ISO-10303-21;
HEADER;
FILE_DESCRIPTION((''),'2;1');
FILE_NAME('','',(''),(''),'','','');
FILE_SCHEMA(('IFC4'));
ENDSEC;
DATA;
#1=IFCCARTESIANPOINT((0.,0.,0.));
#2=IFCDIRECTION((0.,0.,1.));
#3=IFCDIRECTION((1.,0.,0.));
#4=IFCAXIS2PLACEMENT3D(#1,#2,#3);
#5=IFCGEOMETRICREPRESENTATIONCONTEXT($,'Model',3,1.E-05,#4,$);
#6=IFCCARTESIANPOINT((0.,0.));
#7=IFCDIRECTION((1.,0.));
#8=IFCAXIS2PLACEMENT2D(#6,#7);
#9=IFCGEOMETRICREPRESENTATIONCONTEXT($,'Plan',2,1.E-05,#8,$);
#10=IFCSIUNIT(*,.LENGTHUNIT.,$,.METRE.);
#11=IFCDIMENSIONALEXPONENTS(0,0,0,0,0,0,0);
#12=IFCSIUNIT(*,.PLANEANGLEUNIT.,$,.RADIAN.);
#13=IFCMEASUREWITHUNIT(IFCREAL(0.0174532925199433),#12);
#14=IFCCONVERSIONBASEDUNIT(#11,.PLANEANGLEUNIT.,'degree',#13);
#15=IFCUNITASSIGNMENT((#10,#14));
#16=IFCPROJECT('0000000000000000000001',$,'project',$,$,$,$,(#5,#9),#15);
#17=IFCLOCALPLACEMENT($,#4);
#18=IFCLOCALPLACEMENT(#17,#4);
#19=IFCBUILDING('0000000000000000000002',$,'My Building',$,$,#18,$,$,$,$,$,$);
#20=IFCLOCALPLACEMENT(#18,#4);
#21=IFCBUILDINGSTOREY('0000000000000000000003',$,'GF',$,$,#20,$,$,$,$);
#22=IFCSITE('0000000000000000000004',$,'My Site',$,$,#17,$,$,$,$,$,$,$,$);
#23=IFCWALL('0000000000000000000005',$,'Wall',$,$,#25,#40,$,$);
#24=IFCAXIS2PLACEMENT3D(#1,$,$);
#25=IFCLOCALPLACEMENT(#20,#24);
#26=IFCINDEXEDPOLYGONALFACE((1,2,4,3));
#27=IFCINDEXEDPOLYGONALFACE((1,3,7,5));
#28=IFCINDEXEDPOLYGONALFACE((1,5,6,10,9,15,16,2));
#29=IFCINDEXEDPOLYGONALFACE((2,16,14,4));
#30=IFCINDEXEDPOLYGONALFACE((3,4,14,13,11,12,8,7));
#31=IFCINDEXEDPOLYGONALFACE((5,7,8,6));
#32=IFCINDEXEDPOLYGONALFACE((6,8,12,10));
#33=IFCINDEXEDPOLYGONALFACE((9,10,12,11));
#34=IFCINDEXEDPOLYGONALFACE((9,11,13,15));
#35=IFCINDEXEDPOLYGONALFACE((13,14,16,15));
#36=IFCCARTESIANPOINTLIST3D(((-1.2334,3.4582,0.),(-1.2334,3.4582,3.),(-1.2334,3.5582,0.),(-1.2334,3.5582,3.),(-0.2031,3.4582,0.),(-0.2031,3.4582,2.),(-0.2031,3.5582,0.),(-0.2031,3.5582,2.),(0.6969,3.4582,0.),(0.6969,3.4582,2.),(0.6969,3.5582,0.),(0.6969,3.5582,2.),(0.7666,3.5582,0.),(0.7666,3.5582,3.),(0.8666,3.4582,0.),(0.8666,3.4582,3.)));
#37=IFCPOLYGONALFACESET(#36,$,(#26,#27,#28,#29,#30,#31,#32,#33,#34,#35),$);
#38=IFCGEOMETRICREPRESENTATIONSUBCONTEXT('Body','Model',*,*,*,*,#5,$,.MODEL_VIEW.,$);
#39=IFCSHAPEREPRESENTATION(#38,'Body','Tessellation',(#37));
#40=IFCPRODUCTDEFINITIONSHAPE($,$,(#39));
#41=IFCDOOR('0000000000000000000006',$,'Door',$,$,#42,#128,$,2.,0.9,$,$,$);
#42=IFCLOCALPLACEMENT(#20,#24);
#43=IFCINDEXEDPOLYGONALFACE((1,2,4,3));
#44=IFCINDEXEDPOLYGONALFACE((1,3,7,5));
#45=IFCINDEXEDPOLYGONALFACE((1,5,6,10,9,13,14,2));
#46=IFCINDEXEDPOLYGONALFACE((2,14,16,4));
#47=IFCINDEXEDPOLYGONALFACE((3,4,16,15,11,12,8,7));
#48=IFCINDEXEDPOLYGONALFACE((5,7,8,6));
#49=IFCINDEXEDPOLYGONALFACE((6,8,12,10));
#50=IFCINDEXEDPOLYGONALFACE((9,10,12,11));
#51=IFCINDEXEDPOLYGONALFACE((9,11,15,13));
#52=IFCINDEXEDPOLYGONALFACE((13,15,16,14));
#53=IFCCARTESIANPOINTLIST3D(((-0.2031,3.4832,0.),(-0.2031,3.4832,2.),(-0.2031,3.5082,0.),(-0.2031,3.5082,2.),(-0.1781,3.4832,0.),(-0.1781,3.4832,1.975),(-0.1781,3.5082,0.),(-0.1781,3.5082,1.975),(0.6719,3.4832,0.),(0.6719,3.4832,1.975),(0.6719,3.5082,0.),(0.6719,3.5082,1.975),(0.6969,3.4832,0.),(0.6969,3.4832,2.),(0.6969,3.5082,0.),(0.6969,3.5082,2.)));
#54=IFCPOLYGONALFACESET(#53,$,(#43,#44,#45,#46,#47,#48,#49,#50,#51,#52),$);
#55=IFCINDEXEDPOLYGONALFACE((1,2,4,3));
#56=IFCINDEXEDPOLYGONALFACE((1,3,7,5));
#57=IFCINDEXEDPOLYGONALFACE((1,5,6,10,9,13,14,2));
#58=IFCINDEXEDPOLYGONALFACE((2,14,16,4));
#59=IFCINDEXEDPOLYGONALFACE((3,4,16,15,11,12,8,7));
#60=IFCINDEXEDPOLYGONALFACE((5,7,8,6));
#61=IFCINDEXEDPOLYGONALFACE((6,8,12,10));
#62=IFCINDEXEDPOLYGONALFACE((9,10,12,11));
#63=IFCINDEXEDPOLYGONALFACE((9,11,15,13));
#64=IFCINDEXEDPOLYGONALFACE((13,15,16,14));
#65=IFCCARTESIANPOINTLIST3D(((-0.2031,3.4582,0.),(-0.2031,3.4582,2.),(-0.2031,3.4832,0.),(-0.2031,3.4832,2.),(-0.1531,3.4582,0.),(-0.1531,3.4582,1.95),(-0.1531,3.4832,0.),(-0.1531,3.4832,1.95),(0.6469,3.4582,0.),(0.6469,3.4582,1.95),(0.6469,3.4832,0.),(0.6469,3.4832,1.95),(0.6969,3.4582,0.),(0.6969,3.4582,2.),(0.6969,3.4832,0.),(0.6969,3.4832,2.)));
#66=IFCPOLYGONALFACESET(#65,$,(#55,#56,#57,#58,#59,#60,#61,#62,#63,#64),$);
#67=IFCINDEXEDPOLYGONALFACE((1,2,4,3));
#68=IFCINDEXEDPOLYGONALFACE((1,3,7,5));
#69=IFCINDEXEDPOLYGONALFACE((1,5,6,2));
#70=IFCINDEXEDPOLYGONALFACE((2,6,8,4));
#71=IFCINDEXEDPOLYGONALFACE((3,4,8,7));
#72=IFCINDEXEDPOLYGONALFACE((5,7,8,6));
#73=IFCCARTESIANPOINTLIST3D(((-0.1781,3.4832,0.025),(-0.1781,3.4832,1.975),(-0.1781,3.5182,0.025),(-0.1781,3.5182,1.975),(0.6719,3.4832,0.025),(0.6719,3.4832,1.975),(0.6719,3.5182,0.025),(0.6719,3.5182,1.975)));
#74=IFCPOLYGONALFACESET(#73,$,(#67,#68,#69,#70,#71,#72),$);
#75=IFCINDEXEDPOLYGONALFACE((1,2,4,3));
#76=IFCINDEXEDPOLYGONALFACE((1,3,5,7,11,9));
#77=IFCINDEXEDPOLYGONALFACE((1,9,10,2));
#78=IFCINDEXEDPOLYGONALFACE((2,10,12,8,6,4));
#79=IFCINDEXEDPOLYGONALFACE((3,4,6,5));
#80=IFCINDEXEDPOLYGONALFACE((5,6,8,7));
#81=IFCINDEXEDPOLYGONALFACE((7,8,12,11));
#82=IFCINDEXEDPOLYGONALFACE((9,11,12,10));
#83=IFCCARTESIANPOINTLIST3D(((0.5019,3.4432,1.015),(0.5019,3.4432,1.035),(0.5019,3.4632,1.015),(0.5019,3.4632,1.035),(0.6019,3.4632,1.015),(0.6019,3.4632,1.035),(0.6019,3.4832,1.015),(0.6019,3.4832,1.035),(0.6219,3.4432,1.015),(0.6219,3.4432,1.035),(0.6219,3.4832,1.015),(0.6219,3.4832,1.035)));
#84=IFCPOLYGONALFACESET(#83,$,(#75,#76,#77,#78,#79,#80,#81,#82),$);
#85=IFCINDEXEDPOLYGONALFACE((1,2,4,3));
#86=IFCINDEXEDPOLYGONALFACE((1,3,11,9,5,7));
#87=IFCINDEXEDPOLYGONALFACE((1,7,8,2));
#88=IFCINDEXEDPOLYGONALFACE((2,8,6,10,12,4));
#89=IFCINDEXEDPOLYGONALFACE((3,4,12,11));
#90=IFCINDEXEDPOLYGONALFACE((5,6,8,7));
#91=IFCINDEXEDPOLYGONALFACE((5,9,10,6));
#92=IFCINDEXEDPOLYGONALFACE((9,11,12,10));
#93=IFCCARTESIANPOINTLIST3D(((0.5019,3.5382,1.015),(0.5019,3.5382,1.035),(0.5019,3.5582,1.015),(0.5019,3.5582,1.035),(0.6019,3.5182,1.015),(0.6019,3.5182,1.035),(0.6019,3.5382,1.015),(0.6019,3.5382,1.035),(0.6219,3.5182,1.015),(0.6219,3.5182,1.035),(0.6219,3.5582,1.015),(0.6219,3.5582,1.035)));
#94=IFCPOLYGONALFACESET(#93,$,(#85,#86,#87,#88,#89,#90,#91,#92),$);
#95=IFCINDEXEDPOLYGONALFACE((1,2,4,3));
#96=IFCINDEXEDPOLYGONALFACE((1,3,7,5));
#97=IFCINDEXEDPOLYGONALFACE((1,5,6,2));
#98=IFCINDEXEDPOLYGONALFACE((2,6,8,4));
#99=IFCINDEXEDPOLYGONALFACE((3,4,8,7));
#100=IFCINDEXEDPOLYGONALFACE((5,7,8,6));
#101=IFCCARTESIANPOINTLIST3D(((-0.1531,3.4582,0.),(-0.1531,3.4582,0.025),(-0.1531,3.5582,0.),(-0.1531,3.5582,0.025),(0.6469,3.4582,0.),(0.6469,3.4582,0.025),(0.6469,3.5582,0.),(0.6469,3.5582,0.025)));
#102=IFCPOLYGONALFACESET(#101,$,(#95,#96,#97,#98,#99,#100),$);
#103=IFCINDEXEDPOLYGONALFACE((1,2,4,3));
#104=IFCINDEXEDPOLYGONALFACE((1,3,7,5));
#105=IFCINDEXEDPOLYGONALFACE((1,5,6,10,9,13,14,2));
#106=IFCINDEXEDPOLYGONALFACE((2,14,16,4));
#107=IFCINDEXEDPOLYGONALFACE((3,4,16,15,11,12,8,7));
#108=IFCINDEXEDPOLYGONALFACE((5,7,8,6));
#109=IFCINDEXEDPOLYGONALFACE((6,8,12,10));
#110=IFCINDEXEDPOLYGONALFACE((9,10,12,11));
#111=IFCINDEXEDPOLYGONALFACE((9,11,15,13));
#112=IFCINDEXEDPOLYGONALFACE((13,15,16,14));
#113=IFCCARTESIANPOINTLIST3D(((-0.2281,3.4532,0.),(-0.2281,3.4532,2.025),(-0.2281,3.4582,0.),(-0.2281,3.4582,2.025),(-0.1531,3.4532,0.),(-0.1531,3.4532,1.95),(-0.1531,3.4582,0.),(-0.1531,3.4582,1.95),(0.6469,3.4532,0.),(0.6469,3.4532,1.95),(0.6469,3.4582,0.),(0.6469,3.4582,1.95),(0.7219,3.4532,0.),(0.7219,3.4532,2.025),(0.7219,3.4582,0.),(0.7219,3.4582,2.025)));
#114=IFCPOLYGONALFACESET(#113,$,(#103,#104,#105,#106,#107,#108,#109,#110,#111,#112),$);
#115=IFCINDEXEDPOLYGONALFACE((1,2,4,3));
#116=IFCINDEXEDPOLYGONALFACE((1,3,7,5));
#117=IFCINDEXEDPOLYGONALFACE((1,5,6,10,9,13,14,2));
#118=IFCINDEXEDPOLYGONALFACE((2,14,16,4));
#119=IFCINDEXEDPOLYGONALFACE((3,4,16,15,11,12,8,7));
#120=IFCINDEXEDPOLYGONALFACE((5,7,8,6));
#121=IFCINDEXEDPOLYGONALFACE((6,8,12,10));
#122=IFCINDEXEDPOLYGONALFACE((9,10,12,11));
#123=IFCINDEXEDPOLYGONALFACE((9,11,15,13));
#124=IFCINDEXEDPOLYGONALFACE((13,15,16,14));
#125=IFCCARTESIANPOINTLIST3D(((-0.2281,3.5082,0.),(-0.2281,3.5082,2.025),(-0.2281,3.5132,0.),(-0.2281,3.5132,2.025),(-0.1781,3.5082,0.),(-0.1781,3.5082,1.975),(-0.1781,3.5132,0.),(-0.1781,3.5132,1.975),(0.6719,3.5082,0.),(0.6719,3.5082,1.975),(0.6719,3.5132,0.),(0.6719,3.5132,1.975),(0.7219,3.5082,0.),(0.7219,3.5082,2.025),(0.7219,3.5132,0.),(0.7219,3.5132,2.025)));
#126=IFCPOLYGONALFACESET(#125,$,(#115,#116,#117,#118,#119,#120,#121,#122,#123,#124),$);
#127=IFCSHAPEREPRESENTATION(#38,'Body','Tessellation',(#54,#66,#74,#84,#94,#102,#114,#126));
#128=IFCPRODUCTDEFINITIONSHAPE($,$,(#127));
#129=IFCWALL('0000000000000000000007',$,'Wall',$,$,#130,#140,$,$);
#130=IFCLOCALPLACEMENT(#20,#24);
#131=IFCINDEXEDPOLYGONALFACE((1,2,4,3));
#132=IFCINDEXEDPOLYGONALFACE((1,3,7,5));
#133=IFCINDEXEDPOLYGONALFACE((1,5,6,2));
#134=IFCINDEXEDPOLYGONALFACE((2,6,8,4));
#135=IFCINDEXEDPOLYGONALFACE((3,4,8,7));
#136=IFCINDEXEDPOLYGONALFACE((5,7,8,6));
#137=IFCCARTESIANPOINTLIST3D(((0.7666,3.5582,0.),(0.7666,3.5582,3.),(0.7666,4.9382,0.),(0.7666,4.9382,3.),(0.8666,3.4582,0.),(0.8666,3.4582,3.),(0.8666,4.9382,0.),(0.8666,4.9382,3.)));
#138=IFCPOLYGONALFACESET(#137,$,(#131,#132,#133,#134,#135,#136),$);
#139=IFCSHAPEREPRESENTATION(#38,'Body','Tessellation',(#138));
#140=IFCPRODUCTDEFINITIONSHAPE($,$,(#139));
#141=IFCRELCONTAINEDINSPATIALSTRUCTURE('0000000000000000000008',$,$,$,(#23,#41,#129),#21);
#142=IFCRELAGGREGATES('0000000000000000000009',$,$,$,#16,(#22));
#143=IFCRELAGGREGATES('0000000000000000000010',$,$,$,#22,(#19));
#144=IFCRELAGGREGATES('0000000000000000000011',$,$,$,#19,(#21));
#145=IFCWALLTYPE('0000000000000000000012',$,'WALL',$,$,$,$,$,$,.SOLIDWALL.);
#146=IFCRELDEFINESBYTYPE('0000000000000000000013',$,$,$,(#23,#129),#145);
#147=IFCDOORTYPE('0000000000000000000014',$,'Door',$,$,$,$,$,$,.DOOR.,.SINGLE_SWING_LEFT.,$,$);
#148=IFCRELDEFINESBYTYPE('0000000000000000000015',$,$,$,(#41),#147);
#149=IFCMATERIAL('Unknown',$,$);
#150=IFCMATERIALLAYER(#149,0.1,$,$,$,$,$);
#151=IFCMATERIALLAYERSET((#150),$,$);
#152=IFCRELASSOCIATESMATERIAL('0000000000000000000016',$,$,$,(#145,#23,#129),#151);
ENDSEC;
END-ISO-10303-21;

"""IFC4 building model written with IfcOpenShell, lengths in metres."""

from ifc_helpers import new_model, entity, si_unit, converted_unit, frame, origin_with_axes, origin_2d_with_axis, place, context, subcontext, project, spatial, line, indexed_curve, outline, extrude, shape, source, transform, mapped, material, layer, layer_set, layer_usage, type_object, type_shapes, element, fill, save


model = new_model("IFC4")

# Units and contexts
model_context = context("Model", 3, precision=1e-05, world=origin_with_axes())
plan_context = context("Plan", 2, precision=1e-05, world=origin_2d_with_axis())
body_context_1 = subcontext(model_context, "Body", "Model", "MODEL_VIEW")
body_context_2 = subcontext(plan_context, "Body", "Plan", "PLAN_VIEW")
ifc_project = project(units=[si_unit("LENGTHUNIT", "METRE"), converted_unit("PLANEANGLEUNIT", "degree", entity("IfcReal", 0.0174532925199433), si_unit("PLANEANGLEUNIT", "RADIAN"), dimensions=[0, 0, 0, 0, 0, 0, 0])], contexts=[model_context, plan_context])

# Site, building, storey
site_placement = place(None, origin_with_axes())
site = spatial("IfcSite", under=ifc_project, at=site_placement, Name="My Site")
building_placement = place(site_placement, origin_with_axes())
building = spatial("IfcBuilding", under=site, at=building_placement, Name="My Building")
storey_placement = place(building_placement, origin_with_axes())
storey = spatial("IfcBuildingStorey", under=building, at=storey_placement, Name="GF")

# Shared definitions
ifc_material = material(Name="Unknown")

# Shared definitions
ifc_layer = layer(ifc_material, 0.1)
ifc_layer_set = layer_set([ifc_layer])
wall_type = type_object("IfcWallType", Name="WALL", PredefinedType="SOLIDWALL", material=ifc_layer_set)

# Wall, opening, door
ifc_layer_usage_1 = layer_usage(ifc_layer_set, "AXIS2", "POSITIVE", 0.0)
wall_1_placement = place(storey_placement, frame((-1.2334, 3.4582, 0.0), z_axis=(0.0, 0.0, 1.0), x_axis=(1.0, 0.0, 0.0)))
wall_1 = element("IfcWall", 1, at=wall_1_placement, inside=storey, type_object=wall_type, material=ifc_layer_usage_1, Name="Wall", context=body_context_1, shape_type="SweptSolid", body=[
    extrude(outline(indexed_curve([(0.0, 0.0), (0.0, 0.1), (2.0, 0.1), (2.1, 0.0)], segments=[line(1, 2, 3, 4, 1)])), origin_with_axes(), (0.0, 0.0, 1.0), 3.0),
])
shared_shape_1 = source(origin_with_axes(), body_context_1, "Body", "SweptSolid", [
    extrude(outline(indexed_curve([(0.0, 0.0), (0.9, 0.0), (0.9, 2.0), (0.0, 2.0)], segments=[line(1, 2, 3, 4, 1)])), frame((0.0, -0.6, 0.0), z_axis=(0.0, -1.0, 0.0), x_axis=(1.0, 0.0, 0.0)), (0.0, 0.0, -1.0), 1.2),
])
opening_1_placement = place(wall_1_placement, frame((1.0303, 0.0, 0.0), z_axis=(0.0, 0.0, 1.0), x_axis=(1.0, 0.0, 0.0)))
opening_1 = element("IfcOpeningElement", 2, at=opening_1_placement, cuts=wall_1, PredefinedType="OPENING", context=body_context_1, shape_type="MappedRepresentation", body=[
    mapped(shared_shape_1, transform((0.0, 0.0, 0.0), x_axis=(1.0, 0.0, 0.0), y_axis=(0.0, 1.0, 0.0), z_axis=(0.0, 0.0, 1.0), scale=1.0)),
])
door_type = type_object("IfcDoorType", Name="Door", OperationType="SINGLE_SWING_LEFT", PredefinedType="DOOR")
shared_shape_2 = source(origin_with_axes(), body_context_1, "Body", "SweptSolid", [
    extrude(outline(indexed_curve([(0.0, 0.0), (0.0, 2.0), (0.9, 2.0), (0.9, 0.0), (0.875, 0.0), (0.875, 1.975), (0.025, 1.975), (0.025, 0.0)], segments=[line(1, 2, 3, 4, 5, 6, 7, 8, 1)])), frame((0.0, 0.025, 0.0), z_axis=(0.0, -1.0, 0.0), x_axis=(1.0, 0.0, 0.0)), (0.0, 0.0, -1.0), 0.025),
    extrude(outline(indexed_curve([(0.0, 0.0), (0.0, 2.0), (0.9, 2.0), (0.9, 0.0), (0.85, 0.0), (0.85, 1.95), (0.05, 1.95), (0.05, 0.0)], segments=[line(1, 2, 3, 4, 5, 6, 7, 8, 1)])), frame((0.0, 0.0, 0.0), z_axis=(0.0, -1.0, 0.0), x_axis=(1.0, 0.0, 0.0)), (0.0, 0.0, -1.0), 0.025),
    extrude(outline(indexed_curve([(0.0, 0.0), (0.85, 0.0), (0.85, 0.035), (0.0, 0.035)], segments=[line(1, 2, 3, 4, 1)])), frame((0.025, 0.025, 0.025), z_axis=(0.0, 0.0, 1.0), x_axis=(1.0, 0.0, 0.0)), (0.0, 0.0, 1.0), 1.95),
    extrude(outline(indexed_curve([(0.0, 0.0), (0.0, -0.04), (-0.12, -0.04), (-0.12, -0.02), (-0.02, -0.02), (-0.02, 0.0)], segments=[line(1, 2, 3, 4, 5, 6, 1)])), frame((0.825, 0.025, 1.015), z_axis=(0.0, 0.0, 1.0), x_axis=(1.0, 0.0, 0.0)), (0.0, 0.0, 1.0), 0.02),
    extrude(outline(indexed_curve([(0.0, 0.0), (0.0, 0.04), (-0.12, 0.04), (-0.12, 0.02), (-0.02, 0.02), (-0.02, 0.0)], segments=[line(1, 2, 3, 4, 5, 6, 1)])), frame((0.825, 0.06, 1.015), z_axis=(0.0, 0.0, 1.0), x_axis=(1.0, 0.0, 0.0)), (0.0, 0.0, 1.0), 0.02),
    extrude(outline(indexed_curve([(0.0, 0.0), (0.8, 0.0), (0.8, 0.1), (0.0, 0.1)], segments=[line(1, 2, 3, 4, 1)])), frame((0.05, 0.0, 0.0), z_axis=(0.0, 0.0, 1.0), x_axis=(1.0, 0.0, 0.0)), (0.0, 0.0, 1.0), 0.025),
    extrude(outline(indexed_curve([(0.0, 0.0), (0.0, 2.025), (0.95, 2.025), (0.95, 0.0), (0.875, 0.0), (0.875, 1.95), (0.075, 1.95), (0.075, 0.0)], segments=[line(1, 2, 3, 4, 5, 6, 7, 8, 1)])), frame((-0.025, -0.005, 0.0), z_axis=(0.0, -1.0, 0.0), x_axis=(1.0, 0.0, 0.0)), (0.0, 0.0, -1.0), 0.005),
    extrude(outline(indexed_curve([(0.0, 0.0), (0.0, 2.025), (0.95, 2.025), (0.95, 0.0), (0.9, 0.0), (0.9, 1.975), (0.05, 1.975), (0.05, 0.0)], segments=[line(1, 2, 3, 4, 5, 6, 7, 8, 1)])), frame((-0.025, 0.05, 0.0), z_axis=(0.0, -1.0, 0.0), x_axis=(1.0, 0.0, 0.0)), (0.0, 0.0, -1.0), 0.005),
])
shared_shape_3 = source(origin_with_axes(), body_context_2, "Body", "Curve2D", [
    entity("IfcIndexedPolyCurve", entity("IfcCartesianPointList2D", [[0.0, 0.0], [0.0, 0.05], [0.025, 0.05], [0.025, 0.025], [0.05, 0.025], [0.05, 0.0]]), [entity("IfcLineIndex", [1, 2, 3, 4, 5, 6, 1])]),
    entity("IfcIndexedPolyCurve", entity("IfcCartesianPointList2D", [[0.9, 0.0], [0.9, 0.05], [0.875, 0.05], [0.875, 0.025], [0.85, 0.025], [0.85, 0.0]]), [entity("IfcLineIndex", [1, 2, 3, 4, 5, 6, 1])]),
    entity("IfcTrimmedCurve", entity("IfcEllipse", entity("IfcAxis2Placement2D", entity("IfcCartesianPoint", [0.06, 0.05]), entity("IfcDirection", [1.0, 0.0])), 0.815, 0.85), [entity("IfcCartesianPoint", [0.875, 0.05])], [entity("IfcCartesianPoint", [0.06, 0.9])], True, "CARTESIAN"),
    entity("IfcIndexedPolyCurve", entity("IfcCartesianPointList2D", [[0.025, 0.05], [0.06, 0.05], [0.06, 0.9], [0.025, 0.9]]), [entity("IfcLineIndex", [1, 2, 3, 4, 1])]),
])
type_shapes(door_type, [shared_shape_2, shared_shape_3])
door_placement = place(opening_1_placement, origin_with_axes())
door = element("IfcDoor", 3, at=door_placement, inside=storey, type_object=door_type, Name="Door", OverallHeight=2.0, OverallWidth=0.9, shapes=[
    shape(body_context_1, "Body", "MappedRepresentation", [mapped(shared_shape_2, transform((0.0, 0.0, 0.0), x_axis=(1.0, 0.0, 0.0), y_axis=(0.0, 1.0, 0.0), z_axis=(0.0, 0.0, 1.0), scale=1.0))]),
    shape(body_context_2, "Body", "MappedRepresentation", [mapped(shared_shape_3, transform((0.0, 0.0, 0.0), x_axis=(1.0, 0.0, 0.0), y_axis=(0.0, 1.0, 0.0), z_axis=(0.0, 0.0, 1.0), scale=1.0))]),
])
fill(opening_1, door)

# Wall
ifc_layer_usage_2 = layer_usage(ifc_layer_set, "AXIS2", "POSITIVE", 0.0)
wall_2_placement = place(storey_placement, frame((0.8666, 3.4582, 0.0), z_axis=(0.0, 0.0, 1.0), x_axis=(0.0, 1.0, 0.0)))
element("IfcWall", 4, at=wall_2_placement, inside=storey, type_object=wall_type, material=ifc_layer_usage_2, Name="Wall", context=body_context_1, shape_type="SweptSolid", body=[
    extrude(outline(indexed_curve([(0.0, 0.0), (0.1, 0.1), (1.48, 0.1), (1.48, 0.0)], segments=[line(1, 2, 3, 4, 1)])), origin_with_axes(), (0.0, 0.0, 1.0), 3.0),
])

save(model, "model.ifc")
